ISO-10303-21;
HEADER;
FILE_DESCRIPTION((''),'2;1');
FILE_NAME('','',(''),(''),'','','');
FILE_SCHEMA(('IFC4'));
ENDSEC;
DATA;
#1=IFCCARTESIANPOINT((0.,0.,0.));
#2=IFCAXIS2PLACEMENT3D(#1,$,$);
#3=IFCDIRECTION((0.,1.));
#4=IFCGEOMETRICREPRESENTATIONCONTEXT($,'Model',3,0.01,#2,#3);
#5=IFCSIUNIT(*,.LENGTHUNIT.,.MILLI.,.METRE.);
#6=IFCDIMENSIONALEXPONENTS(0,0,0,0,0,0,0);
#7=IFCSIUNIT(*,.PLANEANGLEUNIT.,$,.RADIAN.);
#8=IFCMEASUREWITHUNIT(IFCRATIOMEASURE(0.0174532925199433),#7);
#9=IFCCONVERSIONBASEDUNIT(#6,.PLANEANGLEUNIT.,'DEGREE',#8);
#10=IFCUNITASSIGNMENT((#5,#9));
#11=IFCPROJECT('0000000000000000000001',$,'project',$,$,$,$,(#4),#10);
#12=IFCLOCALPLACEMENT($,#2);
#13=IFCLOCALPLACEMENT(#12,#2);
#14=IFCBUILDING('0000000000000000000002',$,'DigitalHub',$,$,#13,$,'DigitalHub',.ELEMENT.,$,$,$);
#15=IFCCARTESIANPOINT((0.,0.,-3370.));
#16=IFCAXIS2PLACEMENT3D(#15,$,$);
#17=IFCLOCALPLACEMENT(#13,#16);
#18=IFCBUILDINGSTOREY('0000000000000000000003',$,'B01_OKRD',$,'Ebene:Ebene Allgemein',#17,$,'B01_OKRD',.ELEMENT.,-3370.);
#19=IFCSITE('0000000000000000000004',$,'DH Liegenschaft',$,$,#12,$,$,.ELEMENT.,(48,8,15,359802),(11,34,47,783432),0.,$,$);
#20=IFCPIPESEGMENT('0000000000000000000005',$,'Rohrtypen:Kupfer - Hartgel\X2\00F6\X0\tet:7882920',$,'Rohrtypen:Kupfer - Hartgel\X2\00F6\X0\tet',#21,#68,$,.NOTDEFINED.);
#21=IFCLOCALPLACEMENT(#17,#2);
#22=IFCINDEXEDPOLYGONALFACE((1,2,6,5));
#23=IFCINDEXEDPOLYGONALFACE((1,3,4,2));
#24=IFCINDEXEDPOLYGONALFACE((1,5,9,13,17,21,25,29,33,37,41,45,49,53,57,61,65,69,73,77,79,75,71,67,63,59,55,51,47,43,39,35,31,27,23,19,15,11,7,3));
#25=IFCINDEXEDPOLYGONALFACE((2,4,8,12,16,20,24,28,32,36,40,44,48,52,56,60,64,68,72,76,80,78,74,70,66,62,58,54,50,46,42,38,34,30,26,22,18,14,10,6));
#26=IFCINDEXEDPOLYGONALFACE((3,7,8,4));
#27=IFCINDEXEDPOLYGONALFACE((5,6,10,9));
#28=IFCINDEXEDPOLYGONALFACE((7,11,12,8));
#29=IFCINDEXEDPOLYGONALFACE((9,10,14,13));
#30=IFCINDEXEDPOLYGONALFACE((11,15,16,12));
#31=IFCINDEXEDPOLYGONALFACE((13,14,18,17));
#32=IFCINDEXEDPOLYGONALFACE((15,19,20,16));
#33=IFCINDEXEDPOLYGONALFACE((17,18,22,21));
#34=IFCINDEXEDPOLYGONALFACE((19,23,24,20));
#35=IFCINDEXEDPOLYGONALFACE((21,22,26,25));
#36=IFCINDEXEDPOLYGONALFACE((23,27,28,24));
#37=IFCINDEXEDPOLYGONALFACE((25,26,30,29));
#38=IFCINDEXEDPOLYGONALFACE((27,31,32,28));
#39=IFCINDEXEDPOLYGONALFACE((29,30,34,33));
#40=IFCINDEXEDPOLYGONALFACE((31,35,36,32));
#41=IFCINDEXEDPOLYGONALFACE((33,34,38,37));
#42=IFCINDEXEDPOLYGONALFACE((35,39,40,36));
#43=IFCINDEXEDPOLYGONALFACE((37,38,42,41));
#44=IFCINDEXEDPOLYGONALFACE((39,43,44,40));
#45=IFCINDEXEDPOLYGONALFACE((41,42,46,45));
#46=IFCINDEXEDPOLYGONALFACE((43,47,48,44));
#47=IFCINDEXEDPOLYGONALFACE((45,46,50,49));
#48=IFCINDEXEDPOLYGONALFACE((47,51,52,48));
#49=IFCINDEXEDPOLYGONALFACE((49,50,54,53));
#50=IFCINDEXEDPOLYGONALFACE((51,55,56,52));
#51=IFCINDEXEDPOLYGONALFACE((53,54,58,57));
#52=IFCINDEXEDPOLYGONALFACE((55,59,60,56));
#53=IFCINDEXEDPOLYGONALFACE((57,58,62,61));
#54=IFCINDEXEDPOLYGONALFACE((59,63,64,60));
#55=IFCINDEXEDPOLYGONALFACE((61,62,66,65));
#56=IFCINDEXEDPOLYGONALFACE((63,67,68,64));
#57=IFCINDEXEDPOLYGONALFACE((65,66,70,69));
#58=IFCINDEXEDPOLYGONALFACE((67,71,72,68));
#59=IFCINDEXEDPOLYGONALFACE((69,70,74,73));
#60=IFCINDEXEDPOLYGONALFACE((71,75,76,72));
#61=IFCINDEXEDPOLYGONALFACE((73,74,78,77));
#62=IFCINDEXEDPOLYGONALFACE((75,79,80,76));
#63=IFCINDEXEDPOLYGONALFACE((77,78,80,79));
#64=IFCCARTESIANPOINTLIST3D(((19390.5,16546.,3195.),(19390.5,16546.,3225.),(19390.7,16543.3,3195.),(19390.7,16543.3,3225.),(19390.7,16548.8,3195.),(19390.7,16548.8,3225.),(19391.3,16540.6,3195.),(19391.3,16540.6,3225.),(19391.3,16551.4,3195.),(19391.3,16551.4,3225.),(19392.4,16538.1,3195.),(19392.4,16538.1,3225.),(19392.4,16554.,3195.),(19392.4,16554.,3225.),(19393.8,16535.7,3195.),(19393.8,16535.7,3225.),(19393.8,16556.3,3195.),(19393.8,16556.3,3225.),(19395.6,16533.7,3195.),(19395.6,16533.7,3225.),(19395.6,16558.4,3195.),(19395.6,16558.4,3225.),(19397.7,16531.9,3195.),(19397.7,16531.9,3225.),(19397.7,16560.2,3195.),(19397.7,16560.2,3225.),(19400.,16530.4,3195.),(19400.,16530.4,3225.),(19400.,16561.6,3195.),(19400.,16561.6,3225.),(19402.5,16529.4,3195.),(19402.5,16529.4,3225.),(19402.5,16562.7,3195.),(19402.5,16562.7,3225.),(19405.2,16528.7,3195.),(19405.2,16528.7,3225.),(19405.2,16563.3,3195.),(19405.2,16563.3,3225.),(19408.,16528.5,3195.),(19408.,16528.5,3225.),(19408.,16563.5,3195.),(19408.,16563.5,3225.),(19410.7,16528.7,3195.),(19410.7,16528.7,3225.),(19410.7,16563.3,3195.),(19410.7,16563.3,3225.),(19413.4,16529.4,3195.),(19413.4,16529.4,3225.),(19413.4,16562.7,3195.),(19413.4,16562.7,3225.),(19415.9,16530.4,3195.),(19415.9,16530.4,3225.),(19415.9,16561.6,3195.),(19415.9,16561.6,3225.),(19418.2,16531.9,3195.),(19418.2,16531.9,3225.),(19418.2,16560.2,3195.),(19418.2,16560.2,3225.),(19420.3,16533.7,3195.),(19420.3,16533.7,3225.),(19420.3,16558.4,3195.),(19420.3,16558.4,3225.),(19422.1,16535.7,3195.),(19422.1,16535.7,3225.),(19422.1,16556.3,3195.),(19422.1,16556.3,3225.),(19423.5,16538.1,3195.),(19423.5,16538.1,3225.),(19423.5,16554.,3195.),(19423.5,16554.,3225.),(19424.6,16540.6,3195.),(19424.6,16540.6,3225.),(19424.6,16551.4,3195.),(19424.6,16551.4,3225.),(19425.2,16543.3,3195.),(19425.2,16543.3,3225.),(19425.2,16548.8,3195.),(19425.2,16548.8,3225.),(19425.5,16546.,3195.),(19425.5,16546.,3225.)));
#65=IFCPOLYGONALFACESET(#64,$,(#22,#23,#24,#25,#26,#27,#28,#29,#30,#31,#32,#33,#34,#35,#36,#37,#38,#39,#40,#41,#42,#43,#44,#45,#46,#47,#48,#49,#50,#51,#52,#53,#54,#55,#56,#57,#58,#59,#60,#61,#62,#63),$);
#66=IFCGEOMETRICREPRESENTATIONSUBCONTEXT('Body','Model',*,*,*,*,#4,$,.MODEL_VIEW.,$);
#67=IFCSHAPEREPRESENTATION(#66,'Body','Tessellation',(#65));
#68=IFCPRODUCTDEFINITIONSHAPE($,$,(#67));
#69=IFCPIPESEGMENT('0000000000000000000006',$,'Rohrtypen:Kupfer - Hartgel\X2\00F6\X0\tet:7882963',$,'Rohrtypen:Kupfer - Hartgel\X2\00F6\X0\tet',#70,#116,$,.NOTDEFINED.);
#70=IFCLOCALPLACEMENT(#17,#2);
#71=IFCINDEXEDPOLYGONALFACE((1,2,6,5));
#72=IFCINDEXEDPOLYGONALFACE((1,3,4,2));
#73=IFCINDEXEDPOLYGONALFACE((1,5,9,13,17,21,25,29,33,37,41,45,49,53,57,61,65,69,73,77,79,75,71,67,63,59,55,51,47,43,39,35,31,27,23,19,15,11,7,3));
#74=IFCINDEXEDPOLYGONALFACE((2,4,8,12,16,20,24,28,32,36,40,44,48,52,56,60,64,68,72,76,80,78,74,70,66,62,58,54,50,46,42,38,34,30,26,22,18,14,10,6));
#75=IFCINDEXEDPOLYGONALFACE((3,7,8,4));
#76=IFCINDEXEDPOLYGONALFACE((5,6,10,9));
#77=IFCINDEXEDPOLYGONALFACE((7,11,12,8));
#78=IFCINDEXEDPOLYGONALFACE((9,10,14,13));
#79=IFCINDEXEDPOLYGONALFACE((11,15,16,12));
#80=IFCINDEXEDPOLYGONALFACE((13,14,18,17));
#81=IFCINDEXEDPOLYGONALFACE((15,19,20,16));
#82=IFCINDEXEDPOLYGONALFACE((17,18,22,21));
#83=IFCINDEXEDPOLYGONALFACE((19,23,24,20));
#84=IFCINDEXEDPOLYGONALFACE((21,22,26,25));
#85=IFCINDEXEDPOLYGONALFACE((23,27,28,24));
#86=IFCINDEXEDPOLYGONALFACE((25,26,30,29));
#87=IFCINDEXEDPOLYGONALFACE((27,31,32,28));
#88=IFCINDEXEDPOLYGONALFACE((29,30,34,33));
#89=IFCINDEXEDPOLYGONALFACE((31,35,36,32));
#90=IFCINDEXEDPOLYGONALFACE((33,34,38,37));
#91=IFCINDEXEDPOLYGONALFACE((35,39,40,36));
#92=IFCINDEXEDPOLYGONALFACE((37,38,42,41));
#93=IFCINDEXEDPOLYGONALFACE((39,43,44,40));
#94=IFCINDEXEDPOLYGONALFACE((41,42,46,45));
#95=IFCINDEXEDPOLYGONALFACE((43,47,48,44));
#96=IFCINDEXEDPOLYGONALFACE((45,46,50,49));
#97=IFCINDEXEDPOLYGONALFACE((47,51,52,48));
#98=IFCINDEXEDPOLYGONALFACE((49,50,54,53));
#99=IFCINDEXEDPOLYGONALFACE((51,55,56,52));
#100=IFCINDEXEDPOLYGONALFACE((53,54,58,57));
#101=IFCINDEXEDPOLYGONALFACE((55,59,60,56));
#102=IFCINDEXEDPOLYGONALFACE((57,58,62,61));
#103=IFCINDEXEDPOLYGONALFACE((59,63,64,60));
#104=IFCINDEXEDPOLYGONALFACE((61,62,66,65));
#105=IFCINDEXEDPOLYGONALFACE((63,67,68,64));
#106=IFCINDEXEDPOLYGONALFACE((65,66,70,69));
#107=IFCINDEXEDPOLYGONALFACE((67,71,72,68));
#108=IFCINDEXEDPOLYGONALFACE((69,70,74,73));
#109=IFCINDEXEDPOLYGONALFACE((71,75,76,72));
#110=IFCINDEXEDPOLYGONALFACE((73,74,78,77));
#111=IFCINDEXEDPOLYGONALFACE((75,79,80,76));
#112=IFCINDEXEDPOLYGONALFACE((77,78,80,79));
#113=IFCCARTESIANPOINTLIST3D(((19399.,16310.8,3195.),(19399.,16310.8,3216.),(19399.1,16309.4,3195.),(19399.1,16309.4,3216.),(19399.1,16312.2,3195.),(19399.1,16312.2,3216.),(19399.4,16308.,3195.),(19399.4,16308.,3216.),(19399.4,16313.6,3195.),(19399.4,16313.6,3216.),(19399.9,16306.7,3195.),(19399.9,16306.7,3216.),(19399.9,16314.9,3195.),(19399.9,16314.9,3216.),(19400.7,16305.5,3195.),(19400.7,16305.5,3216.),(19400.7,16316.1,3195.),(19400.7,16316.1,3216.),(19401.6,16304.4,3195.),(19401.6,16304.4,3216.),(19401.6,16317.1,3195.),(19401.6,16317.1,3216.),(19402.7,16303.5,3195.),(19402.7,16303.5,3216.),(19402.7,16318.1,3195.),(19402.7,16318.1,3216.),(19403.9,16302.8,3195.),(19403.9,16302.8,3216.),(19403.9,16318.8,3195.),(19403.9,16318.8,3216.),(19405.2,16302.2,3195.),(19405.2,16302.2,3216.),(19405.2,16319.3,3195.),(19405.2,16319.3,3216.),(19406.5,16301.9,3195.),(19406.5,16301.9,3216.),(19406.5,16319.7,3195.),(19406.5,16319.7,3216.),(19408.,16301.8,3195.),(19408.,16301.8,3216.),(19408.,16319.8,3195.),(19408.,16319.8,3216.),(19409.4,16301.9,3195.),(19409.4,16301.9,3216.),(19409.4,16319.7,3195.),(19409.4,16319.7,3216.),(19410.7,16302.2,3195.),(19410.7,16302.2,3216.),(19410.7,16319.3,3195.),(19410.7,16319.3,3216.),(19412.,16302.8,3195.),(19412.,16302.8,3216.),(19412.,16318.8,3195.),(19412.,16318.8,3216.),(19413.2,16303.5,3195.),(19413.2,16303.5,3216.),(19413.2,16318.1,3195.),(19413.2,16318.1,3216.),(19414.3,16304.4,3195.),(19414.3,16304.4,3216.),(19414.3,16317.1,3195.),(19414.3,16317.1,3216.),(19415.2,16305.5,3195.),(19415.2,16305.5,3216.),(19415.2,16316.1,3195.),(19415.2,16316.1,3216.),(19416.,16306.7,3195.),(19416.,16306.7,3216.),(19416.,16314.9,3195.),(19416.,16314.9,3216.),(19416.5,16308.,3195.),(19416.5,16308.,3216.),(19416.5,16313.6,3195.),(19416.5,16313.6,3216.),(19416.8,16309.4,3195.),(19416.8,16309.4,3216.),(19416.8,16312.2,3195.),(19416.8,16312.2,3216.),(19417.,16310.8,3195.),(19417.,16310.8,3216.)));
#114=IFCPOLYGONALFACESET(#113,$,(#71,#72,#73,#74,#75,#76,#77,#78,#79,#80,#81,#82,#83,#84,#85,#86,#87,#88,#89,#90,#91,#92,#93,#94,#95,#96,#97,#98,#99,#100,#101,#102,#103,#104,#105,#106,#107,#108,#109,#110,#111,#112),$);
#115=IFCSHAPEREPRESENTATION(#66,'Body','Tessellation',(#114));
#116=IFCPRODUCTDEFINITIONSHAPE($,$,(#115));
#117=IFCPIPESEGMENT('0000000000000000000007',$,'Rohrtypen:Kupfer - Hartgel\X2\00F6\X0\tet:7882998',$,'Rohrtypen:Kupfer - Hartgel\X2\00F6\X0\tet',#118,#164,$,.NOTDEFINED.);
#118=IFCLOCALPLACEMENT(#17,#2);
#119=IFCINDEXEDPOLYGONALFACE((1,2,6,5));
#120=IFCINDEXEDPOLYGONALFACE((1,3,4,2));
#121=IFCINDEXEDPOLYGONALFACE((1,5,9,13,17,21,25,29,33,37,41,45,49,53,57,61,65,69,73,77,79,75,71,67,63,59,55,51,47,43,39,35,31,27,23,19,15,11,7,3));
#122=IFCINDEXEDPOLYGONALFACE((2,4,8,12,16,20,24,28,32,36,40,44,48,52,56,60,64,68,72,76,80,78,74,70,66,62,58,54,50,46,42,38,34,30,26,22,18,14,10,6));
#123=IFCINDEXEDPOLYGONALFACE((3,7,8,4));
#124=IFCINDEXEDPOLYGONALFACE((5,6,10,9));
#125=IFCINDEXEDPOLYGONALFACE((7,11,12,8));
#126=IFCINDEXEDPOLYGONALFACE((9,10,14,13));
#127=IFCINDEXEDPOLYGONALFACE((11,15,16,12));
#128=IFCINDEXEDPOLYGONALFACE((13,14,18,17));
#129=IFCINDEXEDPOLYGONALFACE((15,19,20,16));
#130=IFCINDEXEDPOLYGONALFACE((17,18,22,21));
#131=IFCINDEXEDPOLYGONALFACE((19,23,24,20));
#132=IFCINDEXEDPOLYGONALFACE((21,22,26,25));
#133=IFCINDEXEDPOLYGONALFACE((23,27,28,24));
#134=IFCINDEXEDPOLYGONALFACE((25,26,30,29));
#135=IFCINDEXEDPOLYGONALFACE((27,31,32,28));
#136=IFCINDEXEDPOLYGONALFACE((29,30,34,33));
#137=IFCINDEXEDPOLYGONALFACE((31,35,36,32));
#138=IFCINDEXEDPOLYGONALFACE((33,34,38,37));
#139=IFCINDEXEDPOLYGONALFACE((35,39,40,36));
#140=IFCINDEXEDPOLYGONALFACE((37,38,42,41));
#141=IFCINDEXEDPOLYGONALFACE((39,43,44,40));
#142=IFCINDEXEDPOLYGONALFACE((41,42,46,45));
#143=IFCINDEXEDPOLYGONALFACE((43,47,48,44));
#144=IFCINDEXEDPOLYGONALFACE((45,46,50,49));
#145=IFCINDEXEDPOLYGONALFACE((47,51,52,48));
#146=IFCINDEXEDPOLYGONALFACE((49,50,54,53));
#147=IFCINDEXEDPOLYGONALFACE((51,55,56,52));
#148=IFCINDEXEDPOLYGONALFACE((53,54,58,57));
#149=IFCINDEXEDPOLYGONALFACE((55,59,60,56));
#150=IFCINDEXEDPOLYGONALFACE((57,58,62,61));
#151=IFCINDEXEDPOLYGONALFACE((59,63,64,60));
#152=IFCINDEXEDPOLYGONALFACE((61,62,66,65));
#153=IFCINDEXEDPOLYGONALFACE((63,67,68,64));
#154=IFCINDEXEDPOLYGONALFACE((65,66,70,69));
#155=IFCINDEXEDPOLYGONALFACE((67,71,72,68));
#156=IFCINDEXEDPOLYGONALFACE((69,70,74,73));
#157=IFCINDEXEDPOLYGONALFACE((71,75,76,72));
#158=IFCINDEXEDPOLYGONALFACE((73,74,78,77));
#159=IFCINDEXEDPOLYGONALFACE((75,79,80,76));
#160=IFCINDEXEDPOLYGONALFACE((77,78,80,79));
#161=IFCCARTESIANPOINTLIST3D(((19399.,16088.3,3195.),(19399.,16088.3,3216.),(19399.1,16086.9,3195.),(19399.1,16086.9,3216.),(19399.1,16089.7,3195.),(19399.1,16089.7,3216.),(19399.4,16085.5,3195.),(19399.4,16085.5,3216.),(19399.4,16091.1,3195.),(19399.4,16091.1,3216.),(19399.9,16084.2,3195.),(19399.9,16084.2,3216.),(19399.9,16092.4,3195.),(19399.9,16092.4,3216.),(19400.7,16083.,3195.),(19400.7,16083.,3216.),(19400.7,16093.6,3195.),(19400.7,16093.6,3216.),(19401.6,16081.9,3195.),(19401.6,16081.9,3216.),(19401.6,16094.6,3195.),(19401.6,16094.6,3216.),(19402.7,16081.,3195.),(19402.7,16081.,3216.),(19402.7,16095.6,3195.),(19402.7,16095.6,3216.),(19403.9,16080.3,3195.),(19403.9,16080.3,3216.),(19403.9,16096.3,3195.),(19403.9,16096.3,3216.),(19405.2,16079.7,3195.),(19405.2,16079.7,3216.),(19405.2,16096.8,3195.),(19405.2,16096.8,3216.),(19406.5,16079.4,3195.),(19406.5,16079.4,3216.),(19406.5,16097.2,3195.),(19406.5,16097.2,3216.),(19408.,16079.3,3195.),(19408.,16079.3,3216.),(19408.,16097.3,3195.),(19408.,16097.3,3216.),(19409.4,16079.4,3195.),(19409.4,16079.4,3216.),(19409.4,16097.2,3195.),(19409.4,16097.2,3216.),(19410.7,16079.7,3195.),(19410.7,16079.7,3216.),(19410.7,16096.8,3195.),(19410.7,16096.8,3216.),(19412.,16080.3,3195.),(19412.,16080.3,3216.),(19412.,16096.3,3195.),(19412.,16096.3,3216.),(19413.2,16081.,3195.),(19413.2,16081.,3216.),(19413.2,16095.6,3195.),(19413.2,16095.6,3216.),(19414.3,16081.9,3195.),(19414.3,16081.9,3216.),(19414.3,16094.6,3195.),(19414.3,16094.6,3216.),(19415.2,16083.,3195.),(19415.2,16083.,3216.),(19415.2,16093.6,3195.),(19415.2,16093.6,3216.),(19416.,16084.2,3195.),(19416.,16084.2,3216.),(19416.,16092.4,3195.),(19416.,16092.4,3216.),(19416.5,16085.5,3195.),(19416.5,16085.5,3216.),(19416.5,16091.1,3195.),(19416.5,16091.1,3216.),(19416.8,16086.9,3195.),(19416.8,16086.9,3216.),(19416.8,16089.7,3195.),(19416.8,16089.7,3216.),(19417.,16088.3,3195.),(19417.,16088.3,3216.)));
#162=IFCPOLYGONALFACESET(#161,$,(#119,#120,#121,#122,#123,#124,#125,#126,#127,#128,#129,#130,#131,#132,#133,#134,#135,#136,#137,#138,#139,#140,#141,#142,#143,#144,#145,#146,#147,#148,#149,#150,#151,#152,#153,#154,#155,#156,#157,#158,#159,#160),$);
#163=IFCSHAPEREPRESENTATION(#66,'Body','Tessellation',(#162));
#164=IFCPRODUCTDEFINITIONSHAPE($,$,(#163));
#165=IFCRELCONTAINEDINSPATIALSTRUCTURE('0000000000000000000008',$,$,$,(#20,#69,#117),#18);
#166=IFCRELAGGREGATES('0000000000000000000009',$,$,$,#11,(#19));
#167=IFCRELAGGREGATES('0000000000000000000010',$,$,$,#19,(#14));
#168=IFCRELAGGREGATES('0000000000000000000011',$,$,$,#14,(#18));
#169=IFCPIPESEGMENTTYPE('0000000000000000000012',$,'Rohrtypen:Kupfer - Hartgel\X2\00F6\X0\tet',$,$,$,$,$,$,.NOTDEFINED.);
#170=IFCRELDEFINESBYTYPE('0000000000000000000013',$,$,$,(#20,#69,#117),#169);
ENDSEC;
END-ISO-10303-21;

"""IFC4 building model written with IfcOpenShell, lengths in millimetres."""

from ifc_helpers import new_model, entity, si_unit, converted_unit, direction, frame, origin, place, context, subcontext, project, spatial, indexed_curve, outline, extrude, type_object, element, save


model = new_model("IFC4")

# Units and contexts
model_context = context("Model", 3, precision=0.01, world=origin(), true_north=direction((0.0, 1.0)))
body_context = subcontext(model_context, "Body", "Model", "MODEL_VIEW")
ifc_project = project(units=[si_unit("LENGTHUNIT", "METRE", prefix="MILLI"), converted_unit("PLANEANGLEUNIT", "DEGREE", entity("IfcRatioMeasure", 0.0174532925199433), si_unit("PLANEANGLEUNIT", "RADIAN"), dimensions=[0, 0, 0, 0, 0, 0, 0])], contexts=[model_context])

# Site, building, storey
site_placement = place(None, origin())
site = spatial("IfcSite", under=ifc_project, at=site_placement, Name="DH Liegenschaft", CompositionType="ELEMENT", RefLatitude=(48, 8, 15, 359802), RefLongitude=(11, 34, 47, 783432), RefElevation=0.0)
building_placement = place(site_placement, origin())
building = spatial("IfcBuilding", under=site, at=building_placement, Name="DigitalHub", LongName="DigitalHub", CompositionType="ELEMENT")
storey_placement = place(building_placement, frame((0.0, 0.0, -3370.0)))
storey = spatial("IfcBuildingStorey", under=building, at=storey_placement, Name="B01_OKRD", ObjectType="Ebene:Ebene Allgemein", LongName="B01_OKRD", CompositionType="ELEMENT", Elevation=-3370.0)

# Pipe segments
pipe_segment_type = type_object("IfcPipeSegmentType", Name="Rohrtypen:Kupfer - Hartgelötet", PredefinedType="NOTDEFINED")
pipe_segment_1_placement = place(storey_placement, frame((19388.9, 16526.9, 3195.0)))
element("IfcPipeSegment", 1, at=pipe_segment_1_placement, inside=storey, type_object=pipe_segment_type, Name="Rohrtypen:Kupfer - Hartgelötet:7882920", ObjectType="Rohrtypen:Kupfer - Hartgelötet", PredefinedType="NOTDEFINED", context=body_context, shape_type="SweptSolid", body=[
    extrude(outline(indexed_curve([(17.5, 0.0), (17.3, 2.7), (16.6, 5.4), (15.6, 7.9), (14.2, 10.3), (12.4, 12.4), (10.3, 14.2), (7.9, 15.6), (5.4, 16.6), (2.7, 17.3), (0.0, 17.5), (-2.7, 17.3), (-5.4, 16.6), (-7.9, 15.6), (-10.3, 14.2), (-12.4, 12.4), (-14.2, 10.3), (-15.6, 7.9), (-16.6, 5.4), (-17.3, 2.7), (-17.5, 0.0), (-17.3, -2.7), (-16.6, -5.4), (-15.6, -7.9), (-14.2, -10.3), (-12.4, -12.4), (-10.3, -14.2), (-7.9, -15.6), (-5.4, -16.6), (-2.7, -17.3), (0.0, -17.5), (2.7, -17.3), (5.4, -16.6), (7.9, -15.6), (10.3, -14.2), (12.4, -12.4), (14.2, -10.3), (15.6, -7.9), (16.6, -5.4), (17.3, -2.7), (17.5, 0.0)], self_intersect=False)), frame((19.1, 19.1, 0.0), z_axis=(0.0, 0.0, 1.0), x_axis=(-1.0, 0.0, 0.0)), (0.0, 0.0, 1.0), 30.0),
])
pipe_segment_2_placement = place(storey_placement, frame((19397.4, 16300.2, 3195.0)))
element("IfcPipeSegment", 2, at=pipe_segment_2_placement, inside=storey, type_object=pipe_segment_type, Name="Rohrtypen:Kupfer - Hartgelötet:7882963", ObjectType="Rohrtypen:Kupfer - Hartgelötet", PredefinedType="NOTDEFINED", context=body_context, shape_type="SweptSolid", body=[
    extrude(outline(indexed_curve([(9.0, 0.0), (8.9, 1.4), (8.6, 2.8), (8.0, 4.1), (7.3, 5.3), (6.4, 6.4), (5.3, 7.3), (4.1, 8.0), (2.8, 8.6), (1.4, 8.9), (0.0, 9.0), (-1.4, 8.9), (-2.8, 8.6), (-4.1, 8.0), (-5.3, 7.3), (-6.4, 6.4), (-7.3, 5.3), (-8.0, 4.1), (-8.6, 2.8), (-8.9, 1.4), (-9.0, 0.0), (-8.9, -1.4), (-8.6, -2.8), (-8.0, -4.1), (-7.3, -5.3), (-6.4, -6.4), (-5.3, -7.3), (-4.1, -8.0), (-2.8, -8.6), (-1.4, -8.9), (0.0, -9.0), (1.4, -8.9), (2.8, -8.6), (4.1, -8.0), (5.3, -7.3), (6.4, -6.4), (7.3, -5.3), (8.0, -4.1), (8.6, -2.8), (8.9, -1.4), (9.0, 0.0)], self_intersect=False)), frame((10.6, 10.6, 0.0)), (0.0, 0.0, 1.0), 21.0),
])
pipe_segment_3_placement = place(storey_placement, frame((19397.4, 16077.7, 3195.0)))
element("IfcPipeSegment", 3, at=pipe_segment_3_placement, inside=storey, type_object=pipe_segment_type, Name="Rohrtypen:Kupfer - Hartgelötet:7882998", ObjectType="Rohrtypen:Kupfer - Hartgelötet", PredefinedType="NOTDEFINED", context=body_context, shape_type="SweptSolid", body=[
    extrude(outline(indexed_curve([(9.0, 0.0), (8.9, 1.4), (8.6, 2.8), (8.0, 4.1), (7.3, 5.3), (6.4, 6.4), (5.3, 7.3), (4.1, 8.0), (2.8, 8.6), (1.4, 8.9), (0.0, 9.0), (-1.4, 8.9), (-2.8, 8.6), (-4.1, 8.0), (-5.3, 7.3), (-6.4, 6.4), (-7.3, 5.3), (-8.0, 4.1), (-8.6, 2.8), (-8.9, 1.4), (-9.0, 0.0), (-8.9, -1.4), (-8.6, -2.8), (-8.0, -4.1), (-7.3, -5.3), (-6.4, -6.4), (-5.3, -7.3), (-4.1, -8.0), (-2.8, -8.6), (-1.4, -8.9), (0.0, -9.0), (1.4, -8.9), (2.8, -8.6), (4.1, -8.0), (5.3, -7.3), (6.4, -6.4), (7.3, -5.3), (8.0, -4.1), (8.6, -2.8), (8.9, -1.4), (9.0, 0.0)], self_intersect=False)), frame((10.6, 10.6, 0.0)), (0.0, 0.0, 1.0), 21.0),
])

save(model, "model.ifc")
